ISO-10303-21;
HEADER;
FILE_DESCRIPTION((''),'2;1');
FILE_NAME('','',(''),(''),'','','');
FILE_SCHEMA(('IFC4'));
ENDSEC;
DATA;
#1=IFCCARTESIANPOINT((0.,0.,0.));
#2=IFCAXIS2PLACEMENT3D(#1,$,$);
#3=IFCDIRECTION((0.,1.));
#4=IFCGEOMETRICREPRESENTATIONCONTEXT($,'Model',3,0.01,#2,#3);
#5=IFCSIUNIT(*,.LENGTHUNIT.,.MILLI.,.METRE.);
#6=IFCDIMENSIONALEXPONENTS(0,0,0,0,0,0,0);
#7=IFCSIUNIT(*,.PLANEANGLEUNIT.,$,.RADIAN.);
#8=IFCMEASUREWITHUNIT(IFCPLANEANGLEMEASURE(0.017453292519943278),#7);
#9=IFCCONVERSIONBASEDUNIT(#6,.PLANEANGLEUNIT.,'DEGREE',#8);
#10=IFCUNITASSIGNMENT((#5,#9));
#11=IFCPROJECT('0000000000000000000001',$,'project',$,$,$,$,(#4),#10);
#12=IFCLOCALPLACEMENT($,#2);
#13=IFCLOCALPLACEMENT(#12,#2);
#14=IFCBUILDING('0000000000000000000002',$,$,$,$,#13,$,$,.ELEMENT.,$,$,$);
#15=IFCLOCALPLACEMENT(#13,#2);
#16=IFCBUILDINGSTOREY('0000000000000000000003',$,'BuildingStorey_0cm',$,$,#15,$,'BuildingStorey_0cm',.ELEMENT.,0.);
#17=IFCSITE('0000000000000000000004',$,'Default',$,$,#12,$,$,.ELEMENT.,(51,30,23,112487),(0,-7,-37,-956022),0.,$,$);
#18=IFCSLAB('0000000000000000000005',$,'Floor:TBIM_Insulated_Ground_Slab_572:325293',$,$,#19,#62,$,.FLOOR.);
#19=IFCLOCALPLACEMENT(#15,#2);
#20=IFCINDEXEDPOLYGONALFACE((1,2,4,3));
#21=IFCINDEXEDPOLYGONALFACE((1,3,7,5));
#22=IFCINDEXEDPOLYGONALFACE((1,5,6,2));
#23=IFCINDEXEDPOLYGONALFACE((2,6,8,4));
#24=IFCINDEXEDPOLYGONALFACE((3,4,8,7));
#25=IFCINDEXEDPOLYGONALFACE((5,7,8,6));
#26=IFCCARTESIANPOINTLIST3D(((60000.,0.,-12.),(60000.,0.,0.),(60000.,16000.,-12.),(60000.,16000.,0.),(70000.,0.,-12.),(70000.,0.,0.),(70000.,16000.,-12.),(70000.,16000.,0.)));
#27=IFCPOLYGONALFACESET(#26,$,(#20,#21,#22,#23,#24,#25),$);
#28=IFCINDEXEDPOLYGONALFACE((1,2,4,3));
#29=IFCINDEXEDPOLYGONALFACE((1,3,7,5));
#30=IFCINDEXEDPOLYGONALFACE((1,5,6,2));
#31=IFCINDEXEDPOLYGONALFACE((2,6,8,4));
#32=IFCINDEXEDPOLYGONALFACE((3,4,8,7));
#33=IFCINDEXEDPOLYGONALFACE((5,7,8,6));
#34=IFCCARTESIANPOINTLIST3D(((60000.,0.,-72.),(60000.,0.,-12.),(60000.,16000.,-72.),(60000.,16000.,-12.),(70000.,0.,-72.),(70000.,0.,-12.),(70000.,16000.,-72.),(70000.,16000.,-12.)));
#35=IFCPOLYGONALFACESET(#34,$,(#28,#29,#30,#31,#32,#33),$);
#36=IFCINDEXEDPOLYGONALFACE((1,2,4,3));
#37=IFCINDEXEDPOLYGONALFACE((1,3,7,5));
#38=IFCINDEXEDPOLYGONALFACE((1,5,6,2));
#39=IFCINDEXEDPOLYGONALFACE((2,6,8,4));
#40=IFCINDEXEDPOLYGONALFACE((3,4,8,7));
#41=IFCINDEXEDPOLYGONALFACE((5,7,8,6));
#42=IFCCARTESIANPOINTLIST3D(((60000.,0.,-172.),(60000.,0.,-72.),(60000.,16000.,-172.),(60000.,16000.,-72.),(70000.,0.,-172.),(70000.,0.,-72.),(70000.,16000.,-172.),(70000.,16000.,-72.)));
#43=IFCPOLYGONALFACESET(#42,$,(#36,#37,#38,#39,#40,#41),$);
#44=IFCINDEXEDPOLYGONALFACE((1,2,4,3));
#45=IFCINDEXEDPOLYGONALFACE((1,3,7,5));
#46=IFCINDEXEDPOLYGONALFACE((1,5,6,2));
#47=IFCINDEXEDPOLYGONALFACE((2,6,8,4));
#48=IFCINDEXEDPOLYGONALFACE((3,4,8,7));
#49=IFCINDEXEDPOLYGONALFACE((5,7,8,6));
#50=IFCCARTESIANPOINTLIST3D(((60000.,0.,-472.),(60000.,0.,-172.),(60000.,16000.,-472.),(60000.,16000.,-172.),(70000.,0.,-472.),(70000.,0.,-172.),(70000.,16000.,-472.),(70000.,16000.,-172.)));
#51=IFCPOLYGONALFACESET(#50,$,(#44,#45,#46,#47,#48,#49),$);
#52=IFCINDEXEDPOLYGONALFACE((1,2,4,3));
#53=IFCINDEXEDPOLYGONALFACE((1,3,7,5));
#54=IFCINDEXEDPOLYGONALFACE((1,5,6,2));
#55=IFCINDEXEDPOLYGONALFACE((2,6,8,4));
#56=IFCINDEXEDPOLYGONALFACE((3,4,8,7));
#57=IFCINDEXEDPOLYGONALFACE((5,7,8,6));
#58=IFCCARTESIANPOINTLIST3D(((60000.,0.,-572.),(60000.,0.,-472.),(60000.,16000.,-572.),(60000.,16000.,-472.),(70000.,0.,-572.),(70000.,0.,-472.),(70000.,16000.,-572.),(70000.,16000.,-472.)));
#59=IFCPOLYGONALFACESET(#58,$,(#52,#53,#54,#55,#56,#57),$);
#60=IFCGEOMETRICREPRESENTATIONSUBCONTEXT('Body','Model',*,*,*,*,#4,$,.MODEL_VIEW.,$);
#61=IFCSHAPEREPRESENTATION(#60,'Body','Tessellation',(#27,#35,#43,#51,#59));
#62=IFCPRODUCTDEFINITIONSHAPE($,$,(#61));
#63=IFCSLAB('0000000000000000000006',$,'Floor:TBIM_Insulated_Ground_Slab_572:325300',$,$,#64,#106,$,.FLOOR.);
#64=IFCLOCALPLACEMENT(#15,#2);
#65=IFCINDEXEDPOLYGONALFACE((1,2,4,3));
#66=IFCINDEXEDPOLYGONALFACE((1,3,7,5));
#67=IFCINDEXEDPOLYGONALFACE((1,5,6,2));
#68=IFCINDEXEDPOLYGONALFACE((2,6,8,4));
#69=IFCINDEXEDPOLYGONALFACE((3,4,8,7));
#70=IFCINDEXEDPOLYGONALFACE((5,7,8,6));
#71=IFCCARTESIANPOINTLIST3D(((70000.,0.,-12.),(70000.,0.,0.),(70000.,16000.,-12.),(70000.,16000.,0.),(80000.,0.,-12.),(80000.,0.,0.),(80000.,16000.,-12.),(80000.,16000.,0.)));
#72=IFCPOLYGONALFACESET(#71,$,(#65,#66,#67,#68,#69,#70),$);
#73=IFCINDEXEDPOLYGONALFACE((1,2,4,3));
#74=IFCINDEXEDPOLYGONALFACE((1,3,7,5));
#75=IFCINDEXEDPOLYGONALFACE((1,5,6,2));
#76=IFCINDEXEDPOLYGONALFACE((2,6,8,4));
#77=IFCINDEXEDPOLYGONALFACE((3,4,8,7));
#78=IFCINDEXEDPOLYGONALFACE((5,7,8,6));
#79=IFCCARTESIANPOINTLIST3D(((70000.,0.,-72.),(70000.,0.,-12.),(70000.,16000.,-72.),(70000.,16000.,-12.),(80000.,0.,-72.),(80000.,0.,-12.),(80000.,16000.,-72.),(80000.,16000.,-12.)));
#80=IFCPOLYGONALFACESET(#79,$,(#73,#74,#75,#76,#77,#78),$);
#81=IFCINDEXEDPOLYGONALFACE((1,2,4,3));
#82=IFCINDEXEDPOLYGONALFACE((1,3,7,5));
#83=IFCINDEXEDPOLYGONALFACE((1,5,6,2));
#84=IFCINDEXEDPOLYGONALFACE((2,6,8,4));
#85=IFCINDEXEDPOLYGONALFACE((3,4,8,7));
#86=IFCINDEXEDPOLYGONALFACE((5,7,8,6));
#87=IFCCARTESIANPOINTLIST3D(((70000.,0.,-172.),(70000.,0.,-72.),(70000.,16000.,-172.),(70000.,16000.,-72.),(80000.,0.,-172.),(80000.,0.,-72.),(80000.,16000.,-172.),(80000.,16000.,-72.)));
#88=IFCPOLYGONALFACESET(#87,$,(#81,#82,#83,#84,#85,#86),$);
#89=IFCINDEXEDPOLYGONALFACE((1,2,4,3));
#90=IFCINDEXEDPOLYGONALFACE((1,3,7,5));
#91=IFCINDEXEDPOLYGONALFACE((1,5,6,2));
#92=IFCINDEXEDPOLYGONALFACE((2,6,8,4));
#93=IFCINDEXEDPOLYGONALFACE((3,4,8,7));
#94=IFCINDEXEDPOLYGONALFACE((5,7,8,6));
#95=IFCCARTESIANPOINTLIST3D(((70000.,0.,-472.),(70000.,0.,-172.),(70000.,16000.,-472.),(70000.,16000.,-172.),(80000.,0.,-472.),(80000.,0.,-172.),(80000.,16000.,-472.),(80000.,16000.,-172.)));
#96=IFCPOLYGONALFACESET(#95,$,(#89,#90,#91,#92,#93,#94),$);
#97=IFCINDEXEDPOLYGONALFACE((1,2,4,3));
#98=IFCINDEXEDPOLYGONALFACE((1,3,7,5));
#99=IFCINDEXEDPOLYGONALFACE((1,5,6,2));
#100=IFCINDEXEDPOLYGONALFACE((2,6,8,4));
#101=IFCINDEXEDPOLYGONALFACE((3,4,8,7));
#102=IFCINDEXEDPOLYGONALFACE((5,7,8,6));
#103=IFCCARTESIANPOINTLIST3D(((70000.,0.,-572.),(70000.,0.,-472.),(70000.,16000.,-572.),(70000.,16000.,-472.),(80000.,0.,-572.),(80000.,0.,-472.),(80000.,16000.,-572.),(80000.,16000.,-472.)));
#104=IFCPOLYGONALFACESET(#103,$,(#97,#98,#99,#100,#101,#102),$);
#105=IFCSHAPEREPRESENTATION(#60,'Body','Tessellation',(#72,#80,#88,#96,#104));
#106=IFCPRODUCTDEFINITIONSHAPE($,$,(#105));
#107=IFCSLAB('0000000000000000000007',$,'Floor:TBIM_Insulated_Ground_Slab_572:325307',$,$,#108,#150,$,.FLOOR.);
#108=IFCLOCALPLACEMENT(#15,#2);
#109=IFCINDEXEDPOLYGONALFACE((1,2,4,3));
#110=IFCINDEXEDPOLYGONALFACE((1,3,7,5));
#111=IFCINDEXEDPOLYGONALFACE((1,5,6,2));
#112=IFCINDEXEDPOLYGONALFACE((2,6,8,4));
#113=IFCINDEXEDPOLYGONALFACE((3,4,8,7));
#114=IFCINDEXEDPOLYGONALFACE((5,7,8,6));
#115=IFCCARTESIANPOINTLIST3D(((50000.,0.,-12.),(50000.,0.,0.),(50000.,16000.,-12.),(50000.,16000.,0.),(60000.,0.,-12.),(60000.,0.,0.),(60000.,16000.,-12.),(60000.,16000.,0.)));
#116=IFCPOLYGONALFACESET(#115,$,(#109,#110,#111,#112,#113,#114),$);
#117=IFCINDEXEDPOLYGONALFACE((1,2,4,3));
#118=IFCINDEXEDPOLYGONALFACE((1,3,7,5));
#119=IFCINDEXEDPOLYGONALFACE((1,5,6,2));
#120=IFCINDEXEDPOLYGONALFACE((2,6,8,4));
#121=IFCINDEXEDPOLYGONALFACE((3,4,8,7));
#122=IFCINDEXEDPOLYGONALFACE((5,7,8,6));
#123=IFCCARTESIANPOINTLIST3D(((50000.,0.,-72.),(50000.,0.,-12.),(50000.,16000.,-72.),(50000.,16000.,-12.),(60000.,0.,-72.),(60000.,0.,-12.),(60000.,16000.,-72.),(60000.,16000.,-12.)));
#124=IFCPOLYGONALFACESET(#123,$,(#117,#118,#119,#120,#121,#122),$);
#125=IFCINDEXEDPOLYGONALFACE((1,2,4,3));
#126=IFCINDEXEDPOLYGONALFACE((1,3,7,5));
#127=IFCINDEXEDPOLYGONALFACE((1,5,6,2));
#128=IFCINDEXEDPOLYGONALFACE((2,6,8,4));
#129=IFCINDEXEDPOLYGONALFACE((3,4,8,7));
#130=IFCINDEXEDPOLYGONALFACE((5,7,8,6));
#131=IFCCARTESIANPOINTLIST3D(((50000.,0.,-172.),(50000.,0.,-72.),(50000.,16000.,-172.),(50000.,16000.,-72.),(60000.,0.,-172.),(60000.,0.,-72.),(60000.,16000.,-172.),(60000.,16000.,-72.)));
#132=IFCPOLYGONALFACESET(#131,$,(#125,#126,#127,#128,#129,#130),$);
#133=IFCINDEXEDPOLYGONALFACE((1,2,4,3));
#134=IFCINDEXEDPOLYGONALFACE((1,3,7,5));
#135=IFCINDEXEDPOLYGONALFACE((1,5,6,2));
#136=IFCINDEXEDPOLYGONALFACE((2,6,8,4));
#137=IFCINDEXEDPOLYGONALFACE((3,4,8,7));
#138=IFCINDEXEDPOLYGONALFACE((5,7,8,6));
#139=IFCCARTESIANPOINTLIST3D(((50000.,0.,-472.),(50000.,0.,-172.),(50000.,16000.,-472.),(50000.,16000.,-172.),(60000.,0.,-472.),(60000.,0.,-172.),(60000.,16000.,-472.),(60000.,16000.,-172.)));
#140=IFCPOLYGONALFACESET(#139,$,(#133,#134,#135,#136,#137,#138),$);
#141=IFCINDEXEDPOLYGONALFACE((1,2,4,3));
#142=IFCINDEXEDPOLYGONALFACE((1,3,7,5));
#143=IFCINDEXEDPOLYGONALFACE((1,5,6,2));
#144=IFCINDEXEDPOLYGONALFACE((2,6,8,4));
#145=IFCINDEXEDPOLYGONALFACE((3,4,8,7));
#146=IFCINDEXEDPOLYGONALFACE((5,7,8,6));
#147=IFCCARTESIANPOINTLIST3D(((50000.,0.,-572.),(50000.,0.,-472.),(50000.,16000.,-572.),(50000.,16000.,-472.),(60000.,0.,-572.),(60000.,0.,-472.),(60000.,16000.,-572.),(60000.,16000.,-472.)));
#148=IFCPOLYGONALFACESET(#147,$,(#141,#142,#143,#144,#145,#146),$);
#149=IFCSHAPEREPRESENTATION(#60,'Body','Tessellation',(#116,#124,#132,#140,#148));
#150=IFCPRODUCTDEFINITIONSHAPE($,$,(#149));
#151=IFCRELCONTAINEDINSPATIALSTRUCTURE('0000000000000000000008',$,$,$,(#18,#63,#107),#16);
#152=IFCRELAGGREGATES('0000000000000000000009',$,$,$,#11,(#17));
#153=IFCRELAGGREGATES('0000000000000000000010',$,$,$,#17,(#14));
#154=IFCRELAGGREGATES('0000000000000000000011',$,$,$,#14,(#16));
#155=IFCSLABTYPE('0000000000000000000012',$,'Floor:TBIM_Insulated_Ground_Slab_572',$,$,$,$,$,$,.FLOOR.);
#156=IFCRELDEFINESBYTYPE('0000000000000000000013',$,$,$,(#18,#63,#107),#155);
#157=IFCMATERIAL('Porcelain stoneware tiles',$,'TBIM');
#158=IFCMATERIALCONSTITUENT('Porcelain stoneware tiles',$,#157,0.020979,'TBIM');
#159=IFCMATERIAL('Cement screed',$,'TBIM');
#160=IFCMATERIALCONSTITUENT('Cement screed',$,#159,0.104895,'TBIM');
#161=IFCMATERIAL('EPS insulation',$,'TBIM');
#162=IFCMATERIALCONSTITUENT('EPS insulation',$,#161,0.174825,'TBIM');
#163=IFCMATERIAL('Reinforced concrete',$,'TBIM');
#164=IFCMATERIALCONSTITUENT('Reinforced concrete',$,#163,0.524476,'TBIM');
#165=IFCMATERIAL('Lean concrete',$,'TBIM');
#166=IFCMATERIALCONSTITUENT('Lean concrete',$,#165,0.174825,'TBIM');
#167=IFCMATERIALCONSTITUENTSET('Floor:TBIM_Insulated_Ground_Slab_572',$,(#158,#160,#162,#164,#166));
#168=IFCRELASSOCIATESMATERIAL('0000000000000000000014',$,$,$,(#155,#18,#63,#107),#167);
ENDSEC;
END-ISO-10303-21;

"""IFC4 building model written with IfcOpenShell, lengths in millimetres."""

from ifc_helpers import new_model, entity, si_unit, converted_unit, direction, frame, origin, place, context, subcontext, project, spatial, indexed_curve, outline, extrude, material, constituent, constituent_set, type_object, element, save


model = new_model("IFC4")

# Units and contexts
model_context = context("Model", 3, precision=0.01, world=origin(), true_north=direction((0.0, 1.0)))
body_context = subcontext(model_context, "Body", "Model", "MODEL_VIEW")
ifc_project = project(units=[si_unit("LENGTHUNIT", "METRE", prefix="MILLI"), converted_unit("PLANEANGLEUNIT", "DEGREE", entity("IfcPlaneAngleMeasure", 0.017453292519943278), si_unit("PLANEANGLEUNIT", "RADIAN"), dimensions=[0, 0, 0, 0, 0, 0, 0])], contexts=[model_context])

# Site, building, storey
site_placement = place(None, origin())
site = spatial("IfcSite", under=ifc_project, at=site_placement, Name="Default", CompositionType="ELEMENT", RefLatitude=(51, 30, 23, 112487), RefLongitude=(0, -7, -37, -956022), RefElevation=0.0)
building_placement = place(site_placement, origin())
building = spatial("IfcBuilding", under=site, at=building_placement, CompositionType="ELEMENT")
storey_placement = place(building_placement, origin())
storey = spatial("IfcBuildingStorey", under=building, at=storey_placement, Name="BuildingStorey_0cm", LongName="BuildingStorey_0cm", CompositionType="ELEMENT", Elevation=0.0)

# Slabs
ifc_material_1 = material(Name="Porcelain stoneware tiles", Category="TBIM")
ifc_constituent_1 = constituent(ifc_material_1, Name="Porcelain stoneware tiles", Category="TBIM", fraction=0.020979)
ifc_material_2 = material(Name="Cement screed", Category="TBIM")
ifc_constituent_2 = constituent(ifc_material_2, Name="Cement screed", Category="TBIM", fraction=0.104895)
ifc_material_3 = material(Name="EPS insulation", Category="TBIM")
ifc_constituent_3 = constituent(ifc_material_3, Name="EPS insulation", Category="TBIM", fraction=0.174825)
ifc_material_4 = material(Name="Reinforced concrete", Category="TBIM")
ifc_constituent_4 = constituent(ifc_material_4, Name="Reinforced concrete", Category="TBIM", fraction=0.524476)
ifc_material_5 = material(Name="Lean concrete", Category="TBIM")
ifc_constituent_5 = constituent(ifc_material_5, Name="Lean concrete", Category="TBIM", fraction=0.174825)
ifc_constituent_set_1 = constituent_set(constituents=[ifc_constituent_1, ifc_constituent_2, ifc_constituent_3, ifc_constituent_4, ifc_constituent_5], Name="Floor:TBIM_Insulated_Ground_Slab_572")
slab_type = type_object("IfcSlabType", Name="Floor:TBIM_Insulated_Ground_Slab_572", PredefinedType="FLOOR", material=ifc_constituent_set_1)
slab_1_placement = place(storey_placement, origin())
element("IfcSlab", 1, at=slab_1_placement, inside=storey, type_object=slab_type, material=ifc_constituent_set_1, Name="Floor:TBIM_Insulated_Ground_Slab_572:325293", PredefinedType="FLOOR", context=body_context, shape_type="SweptSolid", body=[
    extrude(outline(indexed_curve([(-5000.0, -8000.0), (5000.0, -8000.0), (5000.0, 8000.0), (-5000.0, 8000.0), (-5000.0, -8000.0)], self_intersect=False)), frame((65000.0, 8000.0, -12.0), z_axis=(0.0, 0.0, 1.0), x_axis=(-1.0, 0.0, 0.0)), (0.0, 0.0, 1.0), 12.0),
    extrude(outline(indexed_curve([(-5000.0, -8000.0), (5000.0, -8000.0), (5000.0, 8000.0), (-5000.0, 8000.0), (-5000.0, -8000.0)], self_intersect=False)), frame((65000.0, 8000.0, -72.0), z_axis=(0.0, 0.0, 1.0), x_axis=(-1.0, 0.0, 0.0)), (0.0, 0.0, 1.0), 60.0),
    extrude(outline(indexed_curve([(-5000.0, -8000.0), (5000.0, -8000.0), (5000.0, 8000.0), (-5000.0, 8000.0), (-5000.0, -8000.0)], self_intersect=False)), frame((65000.0, 8000.0, -172.0), z_axis=(0.0, 0.0, 1.0), x_axis=(-1.0, 0.0, 0.0)), (0.0, 0.0, 1.0), 100.0),
    extrude(outline(indexed_curve([(-5000.0, -8000.0), (5000.0, -8000.0), (5000.0, 8000.0), (-5000.0, 8000.0), (-5000.0, -8000.0)], self_intersect=False)), frame((65000.0, 8000.0, -472.0), z_axis=(0.0, 0.0, 1.0), x_axis=(-1.0, 0.0, 0.0)), (0.0, 0.0, 1.0), 300.0),
    extrude(outline(indexed_curve([(-5000.0, -8000.0), (5000.0, -8000.0), (5000.0, 8000.0), (-5000.0, 8000.0), (-5000.0, -8000.0)], self_intersect=False)), frame((65000.0, 8000.0, -572.0), z_axis=(0.0, 0.0, 1.0), x_axis=(-1.0, 0.0, 0.0)), (0.0, 0.0, 1.0), 100.0),
])
slab_2_placement = place(storey_placement, origin())
element("IfcSlab", 2, at=slab_2_placement, inside=storey, type_object=slab_type, material=ifc_constituent_set_1, Name="Floor:TBIM_Insulated_Ground_Slab_572:325300", PredefinedType="FLOOR", context=body_context, shape_type="SweptSolid", body=[
    extrude(outline(indexed_curve([(-5000.0, -8000.0), (5000.0, -8000.0), (5000.0, 8000.0), (-5000.0, 8000.0), (-5000.0, -8000.0)], self_intersect=False)), frame((75000.0, 8000.0, -12.0), z_axis=(0.0, 0.0, 1.0), x_axis=(-1.0, 0.0, 0.0)), (0.0, 0.0, 1.0), 12.0),
    extrude(outline(indexed_curve([(-5000.0, -8000.0), (5000.0, -8000.0), (5000.0, 8000.0), (-5000.0, 8000.0), (-5000.0, -8000.0)], self_intersect=False)), frame((75000.0, 8000.0, -72.0), z_axis=(0.0, 0.0, 1.0), x_axis=(-1.0, 0.0, 0.0)), (0.0, 0.0, 1.0), 60.0),
    extrude(outline(indexed_curve([(-5000.0, -8000.0), (5000.0, -8000.0), (5000.0, 8000.0), (-5000.0, 8000.0), (-5000.0, -8000.0)], self_intersect=False)), frame((75000.0, 8000.0, -172.0), z_axis=(0.0, 0.0, 1.0), x_axis=(-1.0, 0.0, 0.0)), (0.0, 0.0, 1.0), 100.0),
    extrude(outline(indexed_curve([(-5000.0, -8000.0), (5000.0, -8000.0), (5000.0, 8000.0), (-5000.0, 8000.0), (-5000.0, -8000.0)], self_intersect=False)), frame((75000.0, 8000.0, -472.0), z_axis=(0.0, 0.0, 1.0), x_axis=(-1.0, 0.0, 0.0)), (0.0, 0.0, 1.0), 300.0),
    extrude(outline(indexed_curve([(-5000.0, -8000.0), (5000.0, -8000.0), (5000.0, 8000.0), (-5000.0, 8000.0), (-5000.0, -8000.0)], self_intersect=False)), frame((75000.0, 8000.0, -572.0), z_axis=(0.0, 0.0, 1.0), x_axis=(-1.0, 0.0, 0.0)), (0.0, 0.0, 1.0), 100.0),
])
slab_3_placement = place(storey_placement, origin())
element("IfcSlab", 3, at=slab_3_placement, inside=storey, type_object=slab_type, material=ifc_constituent_set_1, Name="Floor:TBIM_Insulated_Ground_Slab_572:325307", PredefinedType="FLOOR", context=body_context, shape_type="SweptSolid", body=[
    extrude(outline(indexed_curve([(-5000.0, -8000.0), (5000.0, -8000.0), (5000.0, 8000.0), (-5000.0, 8000.0), (-5000.0, -8000.0)], self_intersect=False)), frame((55000.0, 8000.0, -12.0), z_axis=(0.0, 0.0, 1.0), x_axis=(-1.0, 0.0, 0.0)), (0.0, 0.0, 1.0), 12.0),
    extrude(outline(indexed_curve([(-5000.0, -8000.0), (5000.0, -8000.0), (5000.0, 8000.0), (-5000.0, 8000.0), (-5000.0, -8000.0)], self_intersect=False)), frame((55000.0, 8000.0, -72.0), z_axis=(0.0, 0.0, 1.0), x_axis=(-1.0, 0.0, 0.0)), (0.0, 0.0, 1.0), 60.0),
    extrude(outline(indexed_curve([(-5000.0, -8000.0), (5000.0, -8000.0), (5000.0, 8000.0), (-5000.0, 8000.0), (-5000.0, -8000.0)], self_intersect=False)), frame((55000.0, 8000.0, -172.0), z_axis=(0.0, 0.0, 1.0), x_axis=(-1.0, 0.0, 0.0)), (0.0, 0.0, 1.0), 100.0),
    extrude(outline(indexed_curve([(-5000.0, -8000.0), (5000.0, -8000.0), (5000.0, 8000.0), (-5000.0, 8000.0), (-5000.0, -8000.0)], self_intersect=False)), frame((55000.0, 8000.0, -472.0), z_axis=(0.0, 0.0, 1.0), x_axis=(-1.0, 0.0, 0.0)), (0.0, 0.0, 1.0), 300.0),
    extrude(outline(indexed_curve([(-5000.0, -8000.0), (5000.0, -8000.0), (5000.0, 8000.0), (-5000.0, 8000.0), (-5000.0, -8000.0)], self_intersect=False)), frame((55000.0, 8000.0, -572.0), z_axis=(0.0, 0.0, 1.0), x_axis=(-1.0, 0.0, 0.0)), (0.0, 0.0, 1.0), 100.0),
])

save(model, "model.ifc")
